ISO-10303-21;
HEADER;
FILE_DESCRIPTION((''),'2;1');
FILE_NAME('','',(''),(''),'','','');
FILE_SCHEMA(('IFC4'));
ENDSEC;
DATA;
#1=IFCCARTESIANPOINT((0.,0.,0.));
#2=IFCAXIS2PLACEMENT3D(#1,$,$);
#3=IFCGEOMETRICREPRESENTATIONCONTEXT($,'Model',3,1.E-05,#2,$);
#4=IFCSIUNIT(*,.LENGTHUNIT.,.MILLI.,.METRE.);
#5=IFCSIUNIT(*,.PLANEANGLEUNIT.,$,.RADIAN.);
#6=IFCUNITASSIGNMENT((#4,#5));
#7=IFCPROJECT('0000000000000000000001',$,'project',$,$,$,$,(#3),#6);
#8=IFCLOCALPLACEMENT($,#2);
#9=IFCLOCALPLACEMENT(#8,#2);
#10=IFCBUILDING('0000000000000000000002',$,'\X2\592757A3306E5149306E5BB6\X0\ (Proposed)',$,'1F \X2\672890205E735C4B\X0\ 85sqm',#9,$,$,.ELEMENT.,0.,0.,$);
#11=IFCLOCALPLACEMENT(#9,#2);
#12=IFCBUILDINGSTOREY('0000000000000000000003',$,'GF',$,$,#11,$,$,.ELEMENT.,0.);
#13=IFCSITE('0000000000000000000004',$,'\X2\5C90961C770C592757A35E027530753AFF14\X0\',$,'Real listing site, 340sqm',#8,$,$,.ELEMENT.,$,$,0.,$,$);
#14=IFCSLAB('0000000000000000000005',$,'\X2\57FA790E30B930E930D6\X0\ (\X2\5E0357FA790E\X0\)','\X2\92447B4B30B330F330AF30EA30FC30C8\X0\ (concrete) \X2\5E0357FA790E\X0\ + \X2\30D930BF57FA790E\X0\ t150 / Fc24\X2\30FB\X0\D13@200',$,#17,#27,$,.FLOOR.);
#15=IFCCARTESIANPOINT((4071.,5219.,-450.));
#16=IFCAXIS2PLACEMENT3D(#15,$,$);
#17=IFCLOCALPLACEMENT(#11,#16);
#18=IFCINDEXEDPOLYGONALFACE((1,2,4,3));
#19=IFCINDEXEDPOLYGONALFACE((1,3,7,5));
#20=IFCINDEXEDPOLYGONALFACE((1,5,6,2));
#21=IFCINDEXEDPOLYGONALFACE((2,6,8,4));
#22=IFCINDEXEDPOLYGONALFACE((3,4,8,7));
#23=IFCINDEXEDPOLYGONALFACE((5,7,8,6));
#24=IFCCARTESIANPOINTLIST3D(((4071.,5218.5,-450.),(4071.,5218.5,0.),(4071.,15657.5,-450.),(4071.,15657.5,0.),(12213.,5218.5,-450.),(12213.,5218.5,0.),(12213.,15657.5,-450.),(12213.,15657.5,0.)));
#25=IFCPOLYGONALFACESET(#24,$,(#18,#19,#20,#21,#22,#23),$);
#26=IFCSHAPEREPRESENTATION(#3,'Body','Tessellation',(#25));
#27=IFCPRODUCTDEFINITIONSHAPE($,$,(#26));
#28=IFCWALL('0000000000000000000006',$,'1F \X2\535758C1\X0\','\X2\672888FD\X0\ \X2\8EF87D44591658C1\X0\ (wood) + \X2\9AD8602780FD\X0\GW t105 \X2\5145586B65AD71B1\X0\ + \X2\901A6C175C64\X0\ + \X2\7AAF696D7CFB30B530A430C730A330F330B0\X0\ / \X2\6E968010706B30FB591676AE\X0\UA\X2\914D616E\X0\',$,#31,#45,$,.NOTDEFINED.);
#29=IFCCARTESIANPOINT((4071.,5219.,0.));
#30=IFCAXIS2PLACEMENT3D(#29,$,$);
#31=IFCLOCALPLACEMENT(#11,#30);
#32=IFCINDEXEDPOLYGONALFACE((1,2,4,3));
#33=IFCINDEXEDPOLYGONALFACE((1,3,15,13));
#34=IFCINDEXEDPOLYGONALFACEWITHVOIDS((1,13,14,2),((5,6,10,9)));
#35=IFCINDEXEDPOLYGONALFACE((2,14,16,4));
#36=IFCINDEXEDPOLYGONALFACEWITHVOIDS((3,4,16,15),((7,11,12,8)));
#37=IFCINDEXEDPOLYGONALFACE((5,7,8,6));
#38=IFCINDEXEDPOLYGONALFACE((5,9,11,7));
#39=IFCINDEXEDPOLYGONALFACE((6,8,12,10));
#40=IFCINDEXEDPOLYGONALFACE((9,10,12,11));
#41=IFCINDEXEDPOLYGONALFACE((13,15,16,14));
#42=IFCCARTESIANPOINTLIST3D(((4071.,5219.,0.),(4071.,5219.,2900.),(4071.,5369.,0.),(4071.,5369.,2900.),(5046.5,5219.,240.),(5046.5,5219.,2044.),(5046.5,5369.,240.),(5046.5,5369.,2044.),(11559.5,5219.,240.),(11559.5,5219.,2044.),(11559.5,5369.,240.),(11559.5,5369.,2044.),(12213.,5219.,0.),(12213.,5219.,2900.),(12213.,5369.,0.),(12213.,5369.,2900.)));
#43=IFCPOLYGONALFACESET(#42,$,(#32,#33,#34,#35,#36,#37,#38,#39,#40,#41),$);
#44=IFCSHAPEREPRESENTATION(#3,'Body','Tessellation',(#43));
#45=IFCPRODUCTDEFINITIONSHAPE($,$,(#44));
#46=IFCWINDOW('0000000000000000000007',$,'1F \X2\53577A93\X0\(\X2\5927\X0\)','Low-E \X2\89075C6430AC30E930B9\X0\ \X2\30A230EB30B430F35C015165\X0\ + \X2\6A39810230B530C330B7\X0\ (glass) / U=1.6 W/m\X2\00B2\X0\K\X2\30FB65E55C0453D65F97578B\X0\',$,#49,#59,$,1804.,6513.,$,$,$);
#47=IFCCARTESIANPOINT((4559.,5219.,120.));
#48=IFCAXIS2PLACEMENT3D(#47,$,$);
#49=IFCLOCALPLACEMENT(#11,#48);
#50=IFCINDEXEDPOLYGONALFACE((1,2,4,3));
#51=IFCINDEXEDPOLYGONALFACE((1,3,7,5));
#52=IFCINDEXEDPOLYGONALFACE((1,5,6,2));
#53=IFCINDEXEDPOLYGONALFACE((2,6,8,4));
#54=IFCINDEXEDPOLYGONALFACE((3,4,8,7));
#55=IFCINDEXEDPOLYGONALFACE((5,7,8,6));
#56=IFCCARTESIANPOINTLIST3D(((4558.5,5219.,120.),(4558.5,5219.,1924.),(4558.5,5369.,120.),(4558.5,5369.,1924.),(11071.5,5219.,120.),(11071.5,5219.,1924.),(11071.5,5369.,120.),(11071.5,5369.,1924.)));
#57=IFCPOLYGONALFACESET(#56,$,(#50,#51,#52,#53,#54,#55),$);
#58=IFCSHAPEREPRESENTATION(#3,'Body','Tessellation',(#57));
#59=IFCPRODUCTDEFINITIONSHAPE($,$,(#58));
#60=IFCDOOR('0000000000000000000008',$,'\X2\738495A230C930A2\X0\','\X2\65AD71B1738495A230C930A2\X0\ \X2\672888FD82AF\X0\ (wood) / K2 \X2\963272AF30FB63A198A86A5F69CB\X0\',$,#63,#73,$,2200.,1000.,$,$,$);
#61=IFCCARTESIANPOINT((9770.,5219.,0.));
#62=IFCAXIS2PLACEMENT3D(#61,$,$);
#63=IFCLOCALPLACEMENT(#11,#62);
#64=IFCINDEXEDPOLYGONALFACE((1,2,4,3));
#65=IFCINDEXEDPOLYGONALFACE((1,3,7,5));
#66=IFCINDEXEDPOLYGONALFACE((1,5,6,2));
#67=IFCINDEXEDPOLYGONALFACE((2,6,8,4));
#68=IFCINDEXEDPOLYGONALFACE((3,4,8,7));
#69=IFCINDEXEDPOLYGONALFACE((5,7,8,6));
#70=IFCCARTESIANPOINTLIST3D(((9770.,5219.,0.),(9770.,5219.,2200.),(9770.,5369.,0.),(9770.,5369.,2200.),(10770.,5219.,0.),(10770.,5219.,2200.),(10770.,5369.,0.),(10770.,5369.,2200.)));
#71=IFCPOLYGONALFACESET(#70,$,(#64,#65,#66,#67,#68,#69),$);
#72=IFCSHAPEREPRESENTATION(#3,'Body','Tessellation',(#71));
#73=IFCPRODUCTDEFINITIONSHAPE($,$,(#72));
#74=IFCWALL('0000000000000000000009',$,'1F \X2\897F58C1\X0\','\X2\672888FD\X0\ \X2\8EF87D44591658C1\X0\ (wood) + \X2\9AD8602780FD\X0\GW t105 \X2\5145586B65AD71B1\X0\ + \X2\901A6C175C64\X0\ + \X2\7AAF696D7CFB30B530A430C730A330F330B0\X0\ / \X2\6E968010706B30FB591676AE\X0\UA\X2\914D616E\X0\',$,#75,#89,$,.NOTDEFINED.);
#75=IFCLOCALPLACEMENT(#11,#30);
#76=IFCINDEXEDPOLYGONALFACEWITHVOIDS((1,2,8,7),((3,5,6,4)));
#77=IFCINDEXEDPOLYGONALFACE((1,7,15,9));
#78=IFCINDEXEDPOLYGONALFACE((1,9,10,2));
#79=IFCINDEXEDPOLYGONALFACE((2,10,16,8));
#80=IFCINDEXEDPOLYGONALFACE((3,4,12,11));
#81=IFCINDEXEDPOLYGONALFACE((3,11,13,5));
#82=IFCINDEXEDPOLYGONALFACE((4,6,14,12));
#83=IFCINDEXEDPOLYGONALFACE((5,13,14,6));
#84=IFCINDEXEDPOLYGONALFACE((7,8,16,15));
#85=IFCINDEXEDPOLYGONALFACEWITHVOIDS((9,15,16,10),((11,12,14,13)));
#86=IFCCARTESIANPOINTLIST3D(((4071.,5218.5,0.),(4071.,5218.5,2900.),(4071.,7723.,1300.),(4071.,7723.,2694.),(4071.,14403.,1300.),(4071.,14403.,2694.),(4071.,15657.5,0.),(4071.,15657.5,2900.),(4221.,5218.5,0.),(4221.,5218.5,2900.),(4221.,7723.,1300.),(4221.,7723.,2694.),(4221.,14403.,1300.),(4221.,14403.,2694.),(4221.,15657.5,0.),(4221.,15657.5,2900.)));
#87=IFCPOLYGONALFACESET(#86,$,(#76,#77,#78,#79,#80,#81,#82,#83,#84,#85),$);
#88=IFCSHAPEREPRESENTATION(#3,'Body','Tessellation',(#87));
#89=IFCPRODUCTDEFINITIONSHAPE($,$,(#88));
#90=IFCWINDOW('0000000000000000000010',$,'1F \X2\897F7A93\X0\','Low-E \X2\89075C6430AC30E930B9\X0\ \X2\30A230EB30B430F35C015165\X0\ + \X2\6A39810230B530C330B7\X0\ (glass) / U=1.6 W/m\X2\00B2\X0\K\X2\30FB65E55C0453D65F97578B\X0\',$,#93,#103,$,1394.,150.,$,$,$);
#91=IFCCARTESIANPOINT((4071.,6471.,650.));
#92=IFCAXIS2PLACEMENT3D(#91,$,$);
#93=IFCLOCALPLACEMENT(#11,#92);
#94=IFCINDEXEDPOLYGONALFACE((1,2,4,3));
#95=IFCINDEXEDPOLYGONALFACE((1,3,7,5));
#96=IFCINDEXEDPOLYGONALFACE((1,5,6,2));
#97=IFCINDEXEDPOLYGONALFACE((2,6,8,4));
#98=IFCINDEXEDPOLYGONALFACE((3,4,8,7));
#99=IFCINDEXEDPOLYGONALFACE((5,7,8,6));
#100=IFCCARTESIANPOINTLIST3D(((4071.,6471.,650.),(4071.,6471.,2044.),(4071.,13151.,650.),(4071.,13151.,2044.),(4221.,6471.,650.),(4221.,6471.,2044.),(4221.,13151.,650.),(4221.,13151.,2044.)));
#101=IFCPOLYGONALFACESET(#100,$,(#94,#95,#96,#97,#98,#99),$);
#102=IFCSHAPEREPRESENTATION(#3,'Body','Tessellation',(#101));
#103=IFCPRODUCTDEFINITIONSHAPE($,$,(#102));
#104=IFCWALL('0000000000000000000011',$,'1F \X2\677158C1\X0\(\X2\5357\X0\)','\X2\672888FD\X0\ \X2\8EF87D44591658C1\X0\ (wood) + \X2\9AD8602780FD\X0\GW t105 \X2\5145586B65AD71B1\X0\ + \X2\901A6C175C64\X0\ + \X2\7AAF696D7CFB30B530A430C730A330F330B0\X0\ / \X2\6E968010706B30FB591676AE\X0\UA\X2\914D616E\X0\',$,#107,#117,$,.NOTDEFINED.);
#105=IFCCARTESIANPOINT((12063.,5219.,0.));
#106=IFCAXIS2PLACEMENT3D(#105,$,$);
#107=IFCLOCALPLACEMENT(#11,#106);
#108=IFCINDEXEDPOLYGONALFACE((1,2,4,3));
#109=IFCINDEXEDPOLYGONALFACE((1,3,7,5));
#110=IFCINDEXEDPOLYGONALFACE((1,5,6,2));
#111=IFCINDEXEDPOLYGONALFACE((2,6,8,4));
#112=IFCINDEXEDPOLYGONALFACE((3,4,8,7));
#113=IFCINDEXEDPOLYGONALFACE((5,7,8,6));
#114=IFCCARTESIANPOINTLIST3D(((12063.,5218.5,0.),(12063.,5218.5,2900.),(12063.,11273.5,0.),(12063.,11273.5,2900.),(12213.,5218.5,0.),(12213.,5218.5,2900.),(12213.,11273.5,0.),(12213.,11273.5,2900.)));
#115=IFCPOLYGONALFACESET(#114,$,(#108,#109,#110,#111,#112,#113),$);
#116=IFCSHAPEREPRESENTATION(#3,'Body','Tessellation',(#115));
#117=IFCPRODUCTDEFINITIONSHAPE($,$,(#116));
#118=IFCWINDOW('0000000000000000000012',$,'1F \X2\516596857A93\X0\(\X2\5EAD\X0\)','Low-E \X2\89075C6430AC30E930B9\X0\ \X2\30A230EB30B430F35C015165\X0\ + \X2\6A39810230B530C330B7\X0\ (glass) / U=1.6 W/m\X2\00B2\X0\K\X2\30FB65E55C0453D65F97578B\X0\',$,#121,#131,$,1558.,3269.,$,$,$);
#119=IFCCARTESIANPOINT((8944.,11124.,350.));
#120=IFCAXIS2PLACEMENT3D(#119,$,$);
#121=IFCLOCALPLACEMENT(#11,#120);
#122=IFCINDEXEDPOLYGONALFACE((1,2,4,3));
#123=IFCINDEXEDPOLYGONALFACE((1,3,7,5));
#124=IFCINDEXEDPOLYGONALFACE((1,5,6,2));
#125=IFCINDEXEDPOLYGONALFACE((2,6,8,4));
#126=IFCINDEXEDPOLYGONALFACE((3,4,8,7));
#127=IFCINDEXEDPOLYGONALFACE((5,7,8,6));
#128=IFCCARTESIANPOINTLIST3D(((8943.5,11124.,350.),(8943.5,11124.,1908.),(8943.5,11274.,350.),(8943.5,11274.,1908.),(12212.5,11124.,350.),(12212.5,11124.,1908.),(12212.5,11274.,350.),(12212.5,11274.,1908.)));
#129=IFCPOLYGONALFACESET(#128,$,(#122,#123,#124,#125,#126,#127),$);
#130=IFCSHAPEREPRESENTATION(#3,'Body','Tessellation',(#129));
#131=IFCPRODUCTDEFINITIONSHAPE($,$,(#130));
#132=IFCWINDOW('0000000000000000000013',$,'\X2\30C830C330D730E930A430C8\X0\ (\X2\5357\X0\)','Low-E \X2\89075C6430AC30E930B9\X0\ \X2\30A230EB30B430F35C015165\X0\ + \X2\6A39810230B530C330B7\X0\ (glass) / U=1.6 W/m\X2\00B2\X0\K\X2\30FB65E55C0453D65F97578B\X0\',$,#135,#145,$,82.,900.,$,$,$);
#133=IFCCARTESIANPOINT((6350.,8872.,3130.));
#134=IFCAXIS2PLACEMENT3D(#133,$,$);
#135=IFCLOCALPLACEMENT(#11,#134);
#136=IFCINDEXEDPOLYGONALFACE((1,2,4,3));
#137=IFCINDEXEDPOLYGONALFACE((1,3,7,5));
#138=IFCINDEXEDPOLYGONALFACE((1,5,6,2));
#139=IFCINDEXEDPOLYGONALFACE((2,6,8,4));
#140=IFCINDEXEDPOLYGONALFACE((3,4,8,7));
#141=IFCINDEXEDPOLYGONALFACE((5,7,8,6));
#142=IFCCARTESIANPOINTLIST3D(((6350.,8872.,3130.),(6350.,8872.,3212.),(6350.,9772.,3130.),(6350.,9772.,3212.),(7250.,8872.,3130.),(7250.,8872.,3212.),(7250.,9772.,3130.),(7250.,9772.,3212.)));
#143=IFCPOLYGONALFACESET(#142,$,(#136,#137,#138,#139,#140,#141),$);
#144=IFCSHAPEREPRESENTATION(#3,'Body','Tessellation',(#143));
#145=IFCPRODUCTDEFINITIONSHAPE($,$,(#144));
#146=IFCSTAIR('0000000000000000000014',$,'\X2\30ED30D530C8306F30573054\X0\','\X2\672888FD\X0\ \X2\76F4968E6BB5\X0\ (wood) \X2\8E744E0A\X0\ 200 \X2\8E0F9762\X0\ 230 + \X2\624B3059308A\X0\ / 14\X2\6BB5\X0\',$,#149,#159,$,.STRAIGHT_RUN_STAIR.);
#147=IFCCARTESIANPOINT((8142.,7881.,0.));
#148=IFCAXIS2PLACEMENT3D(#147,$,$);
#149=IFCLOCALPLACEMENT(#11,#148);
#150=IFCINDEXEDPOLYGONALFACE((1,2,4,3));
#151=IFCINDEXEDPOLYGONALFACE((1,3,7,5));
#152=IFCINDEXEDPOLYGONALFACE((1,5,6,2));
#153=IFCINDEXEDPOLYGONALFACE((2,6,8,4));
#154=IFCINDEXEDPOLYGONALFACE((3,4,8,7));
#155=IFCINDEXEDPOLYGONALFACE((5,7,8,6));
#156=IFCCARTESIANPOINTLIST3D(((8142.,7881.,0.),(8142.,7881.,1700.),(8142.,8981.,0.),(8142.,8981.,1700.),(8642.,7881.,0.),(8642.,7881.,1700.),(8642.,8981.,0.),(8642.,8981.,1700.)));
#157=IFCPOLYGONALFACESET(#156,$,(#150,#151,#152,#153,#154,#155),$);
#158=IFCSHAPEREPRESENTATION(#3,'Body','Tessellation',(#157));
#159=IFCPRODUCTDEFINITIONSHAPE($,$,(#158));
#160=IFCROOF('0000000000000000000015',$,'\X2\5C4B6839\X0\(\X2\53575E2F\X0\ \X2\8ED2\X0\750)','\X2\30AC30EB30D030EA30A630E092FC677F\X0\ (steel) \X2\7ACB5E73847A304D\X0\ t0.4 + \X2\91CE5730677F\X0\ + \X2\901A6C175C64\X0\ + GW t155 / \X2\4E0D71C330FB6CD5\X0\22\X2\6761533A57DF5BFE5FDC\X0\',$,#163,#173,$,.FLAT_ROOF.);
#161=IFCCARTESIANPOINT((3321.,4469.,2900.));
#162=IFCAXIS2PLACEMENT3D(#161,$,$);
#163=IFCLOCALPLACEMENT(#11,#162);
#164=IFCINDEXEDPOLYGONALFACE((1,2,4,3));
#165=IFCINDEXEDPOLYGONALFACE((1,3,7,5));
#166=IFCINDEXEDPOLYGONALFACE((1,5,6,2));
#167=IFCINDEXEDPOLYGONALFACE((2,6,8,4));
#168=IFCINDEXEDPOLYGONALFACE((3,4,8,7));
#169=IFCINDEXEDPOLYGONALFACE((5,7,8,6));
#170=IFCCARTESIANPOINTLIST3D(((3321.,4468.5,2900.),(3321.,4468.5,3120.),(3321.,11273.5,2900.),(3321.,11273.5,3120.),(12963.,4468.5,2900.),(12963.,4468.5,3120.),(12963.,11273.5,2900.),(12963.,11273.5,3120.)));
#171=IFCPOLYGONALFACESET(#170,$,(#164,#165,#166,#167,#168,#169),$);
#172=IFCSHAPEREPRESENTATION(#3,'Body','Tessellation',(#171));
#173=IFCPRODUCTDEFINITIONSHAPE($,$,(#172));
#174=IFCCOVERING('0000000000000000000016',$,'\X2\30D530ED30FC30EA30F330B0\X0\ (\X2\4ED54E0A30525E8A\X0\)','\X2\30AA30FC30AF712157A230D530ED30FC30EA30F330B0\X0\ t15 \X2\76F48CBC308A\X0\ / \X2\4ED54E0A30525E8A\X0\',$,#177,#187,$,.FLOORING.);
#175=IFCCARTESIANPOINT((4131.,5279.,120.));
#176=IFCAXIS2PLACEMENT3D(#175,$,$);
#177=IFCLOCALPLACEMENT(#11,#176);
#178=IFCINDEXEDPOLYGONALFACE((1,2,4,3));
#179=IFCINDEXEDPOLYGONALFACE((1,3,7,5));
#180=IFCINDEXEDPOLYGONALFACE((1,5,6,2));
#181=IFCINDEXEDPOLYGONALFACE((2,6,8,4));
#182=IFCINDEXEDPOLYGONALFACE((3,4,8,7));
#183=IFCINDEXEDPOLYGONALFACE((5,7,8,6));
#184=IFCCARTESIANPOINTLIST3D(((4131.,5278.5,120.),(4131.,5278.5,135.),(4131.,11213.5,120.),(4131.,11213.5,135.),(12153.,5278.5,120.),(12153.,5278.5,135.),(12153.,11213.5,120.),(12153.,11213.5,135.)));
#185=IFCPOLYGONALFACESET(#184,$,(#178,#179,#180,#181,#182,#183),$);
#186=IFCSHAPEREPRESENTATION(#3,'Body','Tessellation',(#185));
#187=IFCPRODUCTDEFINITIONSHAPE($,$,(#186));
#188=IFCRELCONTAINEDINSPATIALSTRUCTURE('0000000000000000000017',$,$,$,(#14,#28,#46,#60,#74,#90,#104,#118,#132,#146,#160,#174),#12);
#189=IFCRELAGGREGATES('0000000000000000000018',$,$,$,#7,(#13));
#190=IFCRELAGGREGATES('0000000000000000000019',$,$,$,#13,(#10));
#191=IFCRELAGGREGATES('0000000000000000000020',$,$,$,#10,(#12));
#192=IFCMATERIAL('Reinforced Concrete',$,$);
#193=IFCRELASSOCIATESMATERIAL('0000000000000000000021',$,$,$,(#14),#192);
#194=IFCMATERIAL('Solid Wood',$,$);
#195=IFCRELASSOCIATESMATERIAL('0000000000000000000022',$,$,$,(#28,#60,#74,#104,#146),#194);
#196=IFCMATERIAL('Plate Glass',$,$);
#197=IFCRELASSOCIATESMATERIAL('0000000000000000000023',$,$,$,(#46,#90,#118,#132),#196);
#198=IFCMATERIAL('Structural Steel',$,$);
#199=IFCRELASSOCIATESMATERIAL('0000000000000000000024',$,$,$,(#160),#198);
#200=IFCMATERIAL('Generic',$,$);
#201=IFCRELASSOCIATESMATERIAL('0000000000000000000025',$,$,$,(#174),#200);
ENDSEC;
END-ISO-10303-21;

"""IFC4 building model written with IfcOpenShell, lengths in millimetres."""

from ifc_helpers import new_model, si_unit, frame, frame_2d, origin, place, context, project, spatial, rectangle, extrude, material, element, fill, save


model = new_model("IFC4")

# Units and contexts
model_context = context("Model", 3, precision=1e-05, world=origin())
ifc_project = project(units=[si_unit("LENGTHUNIT", "METRE", prefix="MILLI"), si_unit("PLANEANGLEUNIT", "RADIAN")], contexts=[model_context])

# Site, building, storey
site_placement = place(None, origin())
site = spatial("IfcSite", under=ifc_project, at=site_placement, Name="岐阜県大垣市田町４", ObjectType="Real listing site, 340sqm", CompositionType="ELEMENT", RefElevation=0.0)
building_placement = place(site_placement, origin())
building = spatial("IfcBuilding", under=site, at=building_placement, Name="大垣の光の家 (Proposed)", ObjectType="1F 木造平屋 85sqm", CompositionType="ELEMENT", ElevationOfRefHeight=0.0, ElevationOfTerrain=0.0)
storey_placement = place(building_placement, origin())
storey = spatial("IfcBuildingStorey", under=building, at=storey_placement, Name="GF", CompositionType="ELEMENT", Elevation=0.0)

# Slab
ifc_material_1 = material(Name="Reinforced Concrete")
slab_1_placement = place(storey_placement, frame((4071.0, 5219.0, -450.0)))
element("IfcSlab", 1, at=slab_1_placement, inside=storey, material=ifc_material_1, Name="基礎スラブ (布基礎)", Description="鉄筋コンクリート (concrete) 布基礎 + ベタ基礎 t150 / Fc24・D13@200", PredefinedType="FLOOR", context=model_context, shape_type="SweptSolid", body=[
    extrude(rectangle(XDim=8142.0, YDim=10439.0, at=frame_2d((4071.0, 5219.0))), frame((4071.0, 5219.0, -450.0)), (0.0, 0.0, 1.0), 450.0),
])
ifc_material_2 = material(Name="Solid Wood")

# Wall, openings, window, door
wall_1_placement = place(storey_placement, frame((4071.0, 5219.0, 0.0)))
wall_1 = element("IfcWall", 2, at=wall_1_placement, inside=storey, material=ifc_material_2, Name="1F 南壁", Description="木製 軸組外壁 (wood) + 高性能GW t105 充填断熱 + 通気層 + 窯業系サイディング / 準耐火・外皮UA配慮", PredefinedType="NOTDEFINED", context=model_context, shape_type="SweptSolid", body=[
    extrude(rectangle(XDim=8142.0, YDim=150.0, at=frame_2d((4071.0, 75.0))), frame((4071.0, 5219.0, 0.0)), (0.0, 0.0, 1.0), 2900.0),
])
opening_1_placement = place(storey_placement, frame((4559.0, 5219.0, 120.0)))
opening_1 = element("IfcOpeningElement", 3, at=opening_1_placement, cuts=wall_1, PredefinedType="NOTDEFINED", context=model_context, shape_type="SweptSolid", body=[
    extrude(rectangle(XDim=6513.0, YDim=150.0, at=frame_2d((3256.0, 75.0))), frame((4559.0, 5219.0, 120.0)), (0.0, 0.0, 1.0), 1804.0),
])
opening_2_placement = place(storey_placement, frame((9770.0, 5219.0, 0.0)))
opening_2 = element("IfcOpeningElement", 4, at=opening_2_placement, cuts=wall_1, PredefinedType="NOTDEFINED", context=model_context, shape_type="SweptSolid", body=[
    extrude(rectangle(XDim=1000.0, YDim=150.0, at=frame_2d((500.0, 75.0))), frame((9770.0, 5219.0, 0.0)), (0.0, 0.0, 1.0), 2200.0),
])
ifc_material_3 = material(Name="Plate Glass")
window_1_placement = place(storey_placement, frame((4559.0, 5219.0, 120.0)))
window_1 = element("IfcWindow", 5, at=window_1_placement, inside=storey, material=ifc_material_3, Name="1F 南窓(大)", Description="Low-E 複層ガラス アルゴン封入 + 樹脂サッシ (glass) / U=1.6 W/m²K・日射取得型", OverallHeight=1804.0, OverallWidth=6513.0, context=model_context, shape_type="SweptSolid", body=[
    extrude(rectangle(XDim=6513.0, YDim=150.0, at=frame_2d((3256.0, 75.0))), frame((4559.0, 5219.0, 120.0)), (0.0, 0.0, 1.0), 1804.0),
])
fill(opening_1, window_1)
door_1_placement = place(storey_placement, frame((9770.0, 5219.0, 0.0)))
door_1 = element("IfcDoor", 6, at=door_1_placement, inside=storey, material=ifc_material_2, Name="玄関ドア", Description="断熱玄関ドア 木製芯 (wood) / K2 防犯・採風機構", OverallHeight=2200.0, OverallWidth=1000.0, context=model_context, shape_type="SweptSolid", body=[
    extrude(rectangle(XDim=1000.0, YDim=150.0, at=frame_2d((500.0, 75.0))), frame((9770.0, 5219.0, 0.0)), (0.0, 0.0, 1.0), 2200.0),
])
fill(opening_2, door_1)

# Walls, openings, windows
wall_2_placement = place(storey_placement, frame((4071.0, 5219.0, 0.0)))
wall_2 = element("IfcWall", 7, at=wall_2_placement, inside=storey, material=ifc_material_2, Name="1F 西壁", Description="木製 軸組外壁 (wood) + 高性能GW t105 充填断熱 + 通気層 + 窯業系サイディング / 準耐火・外皮UA配慮", PredefinedType="NOTDEFINED", context=model_context, shape_type="SweptSolid", body=[
    extrude(rectangle(XDim=150.0, YDim=10439.0, at=frame_2d((75.0, 5219.0))), frame((4071.0, 5219.0, 0.0)), (0.0, 0.0, 1.0), 2900.0),
])
opening_3_placement = place(storey_placement, frame((4071.0, 6471.0, 650.0)))
opening_3 = element("IfcOpeningElement", 8, at=opening_3_placement, cuts=wall_2, PredefinedType="NOTDEFINED", context=model_context, shape_type="SweptSolid", body=[
    extrude(rectangle(XDim=150.0, YDim=6680.0, at=frame_2d((75.0, 3340.0))), frame((4071.0, 6471.0, 650.0)), (0.0, 0.0, 1.0), 1394.0),
])
window_2_placement = place(storey_placement, frame((4071.0, 6471.0, 650.0)))
window_2 = element("IfcWindow", 9, at=window_2_placement, inside=storey, material=ifc_material_3, Name="1F 西窓", Description="Low-E 複層ガラス アルゴン封入 + 樹脂サッシ (glass) / U=1.6 W/m²K・日射取得型", OverallHeight=1394.0, OverallWidth=150.0, context=model_context, shape_type="SweptSolid", body=[
    extrude(rectangle(XDim=150.0, YDim=6680.0, at=frame_2d((75.0, 3340.0))), frame((4071.0, 6471.0, 650.0)), (0.0, 0.0, 1.0), 1394.0),
])
fill(opening_3, window_2)
wall_3_placement = place(storey_placement, frame((12063.0, 5219.0, 0.0)))
wall_3 = element("IfcWall", 10, at=wall_3_placement, inside=storey, material=ifc_material_2, Name="1F 東壁(南)", Description="木製 軸組外壁 (wood) + 高性能GW t105 充填断熱 + 通気層 + 窯業系サイディング / 準耐火・外皮UA配慮", PredefinedType="NOTDEFINED", context=model_context, shape_type="SweptSolid", body=[
    extrude(rectangle(XDim=150.0, YDim=6055.0, at=frame_2d((75.0, 3027.0))), frame((12063.0, 5219.0, 0.0)), (0.0, 0.0, 1.0), 2900.0),
])
opening_4_placement = place(storey_placement, frame((8944.0, 11124.0, 350.0)))
opening_4 = element("IfcOpeningElement", 11, at=opening_4_placement, cuts=wall_3, PredefinedType="NOTDEFINED", context=model_context, shape_type="SweptSolid", body=[
    extrude(rectangle(XDim=3269.0, YDim=150.0, at=frame_2d((1634.0, 75.0))), frame((8944.0, 11124.0, 350.0)), (0.0, 0.0, 1.0), 1558.0),
])
window_3_placement = place(storey_placement, frame((8944.0, 11124.0, 350.0)))
window_3 = element("IfcWindow", 12, at=window_3_placement, inside=storey, material=ifc_material_3, Name="1F 入隅窓(庭)", Description="Low-E 複層ガラス アルゴン封入 + 樹脂サッシ (glass) / U=1.6 W/m²K・日射取得型", OverallHeight=1558.0, OverallWidth=3269.0, context=model_context, shape_type="SweptSolid", body=[
    extrude(rectangle(XDim=3269.0, YDim=150.0, at=frame_2d((1634.0, 75.0))), frame((8944.0, 11124.0, 350.0)), (0.0, 0.0, 1.0), 1558.0),
])
fill(opening_4, window_3)

# Window
window_4_placement = place(storey_placement, frame((6350.0, 8872.0, 3130.0)))
element("IfcWindow", 13, at=window_4_placement, inside=storey, material=ifc_material_3, Name="トップライト (南)", Description="Low-E 複層ガラス アルゴン封入 + 樹脂サッシ (glass) / U=1.6 W/m²K・日射取得型", OverallHeight=82.0, OverallWidth=900.0, context=model_context, shape_type="SweptSolid", body=[
    extrude(rectangle(XDim=900.0, YDim=900.0, at=frame_2d((450.0, 450.0))), frame((6350.0, 8872.0, 3130.0)), (0.0, 0.0, 1.0), 82.0),
])

# Stair
stair_placement = place(storey_placement, frame((8142.0, 7881.0, 0.0)))
element("IfcStair", 14, at=stair_placement, inside=storey, material=ifc_material_2, Name="ロフトはしご", Description="木製 直階段 (wood) 蹴上 200 踏面 230 + 手すり / 14段", PredefinedType="STRAIGHT_RUN_STAIR", context=model_context, shape_type="SweptSolid", body=[
    extrude(rectangle(XDim=500.0, YDim=1100.0, at=frame_2d((250.0, 550.0))), frame((8142.0, 7881.0, 0.0)), (0.0, 0.0, 1.0), 1700.0),
])

# Roof
ifc_material_4 = material(Name="Structural Steel")
roof_placement = place(storey_placement, frame((3321.0, 4469.0, 2900.0)))
element("IfcRoof", 15, at=roof_placement, inside=storey, material=ifc_material_4, Name="屋根(南帯 軒750)", Description="ガルバリウム鋼板 (steel) 立平葺き t0.4 + 野地板 + 通気層 + GW t155 / 不燃・法22条区域対応", PredefinedType="FLAT_ROOF", context=model_context, shape_type="SweptSolid", body=[
    extrude(rectangle(XDim=9642.0, YDim=6805.0, at=frame_2d((4821.0, 3402.0))), frame((3321.0, 4469.0, 2900.0)), (0.0, 0.0, 1.0), 220.0),
])

# Covering
ifc_material_5 = material(Name="Generic")
covering_placement = place(storey_placement, frame((4131.0, 5279.0, 120.0)))
element("IfcCovering", 16, at=covering_placement, inside=storey, material=ifc_material_5, Name="フローリング (仕上げ床)", Description="オーク無垢フローリング t15 直貼り / 仕上げ床", PredefinedType="FLOORING", context=model_context, shape_type="SweptSolid", body=[
    extrude(rectangle(XDim=8022.0, YDim=5935.0, at=frame_2d((4011.0, 2967.0))), frame((4131.0, 5279.0, 120.0)), (0.0, 0.0, 1.0), 15.0),
])

save(model, "model.ifc")
